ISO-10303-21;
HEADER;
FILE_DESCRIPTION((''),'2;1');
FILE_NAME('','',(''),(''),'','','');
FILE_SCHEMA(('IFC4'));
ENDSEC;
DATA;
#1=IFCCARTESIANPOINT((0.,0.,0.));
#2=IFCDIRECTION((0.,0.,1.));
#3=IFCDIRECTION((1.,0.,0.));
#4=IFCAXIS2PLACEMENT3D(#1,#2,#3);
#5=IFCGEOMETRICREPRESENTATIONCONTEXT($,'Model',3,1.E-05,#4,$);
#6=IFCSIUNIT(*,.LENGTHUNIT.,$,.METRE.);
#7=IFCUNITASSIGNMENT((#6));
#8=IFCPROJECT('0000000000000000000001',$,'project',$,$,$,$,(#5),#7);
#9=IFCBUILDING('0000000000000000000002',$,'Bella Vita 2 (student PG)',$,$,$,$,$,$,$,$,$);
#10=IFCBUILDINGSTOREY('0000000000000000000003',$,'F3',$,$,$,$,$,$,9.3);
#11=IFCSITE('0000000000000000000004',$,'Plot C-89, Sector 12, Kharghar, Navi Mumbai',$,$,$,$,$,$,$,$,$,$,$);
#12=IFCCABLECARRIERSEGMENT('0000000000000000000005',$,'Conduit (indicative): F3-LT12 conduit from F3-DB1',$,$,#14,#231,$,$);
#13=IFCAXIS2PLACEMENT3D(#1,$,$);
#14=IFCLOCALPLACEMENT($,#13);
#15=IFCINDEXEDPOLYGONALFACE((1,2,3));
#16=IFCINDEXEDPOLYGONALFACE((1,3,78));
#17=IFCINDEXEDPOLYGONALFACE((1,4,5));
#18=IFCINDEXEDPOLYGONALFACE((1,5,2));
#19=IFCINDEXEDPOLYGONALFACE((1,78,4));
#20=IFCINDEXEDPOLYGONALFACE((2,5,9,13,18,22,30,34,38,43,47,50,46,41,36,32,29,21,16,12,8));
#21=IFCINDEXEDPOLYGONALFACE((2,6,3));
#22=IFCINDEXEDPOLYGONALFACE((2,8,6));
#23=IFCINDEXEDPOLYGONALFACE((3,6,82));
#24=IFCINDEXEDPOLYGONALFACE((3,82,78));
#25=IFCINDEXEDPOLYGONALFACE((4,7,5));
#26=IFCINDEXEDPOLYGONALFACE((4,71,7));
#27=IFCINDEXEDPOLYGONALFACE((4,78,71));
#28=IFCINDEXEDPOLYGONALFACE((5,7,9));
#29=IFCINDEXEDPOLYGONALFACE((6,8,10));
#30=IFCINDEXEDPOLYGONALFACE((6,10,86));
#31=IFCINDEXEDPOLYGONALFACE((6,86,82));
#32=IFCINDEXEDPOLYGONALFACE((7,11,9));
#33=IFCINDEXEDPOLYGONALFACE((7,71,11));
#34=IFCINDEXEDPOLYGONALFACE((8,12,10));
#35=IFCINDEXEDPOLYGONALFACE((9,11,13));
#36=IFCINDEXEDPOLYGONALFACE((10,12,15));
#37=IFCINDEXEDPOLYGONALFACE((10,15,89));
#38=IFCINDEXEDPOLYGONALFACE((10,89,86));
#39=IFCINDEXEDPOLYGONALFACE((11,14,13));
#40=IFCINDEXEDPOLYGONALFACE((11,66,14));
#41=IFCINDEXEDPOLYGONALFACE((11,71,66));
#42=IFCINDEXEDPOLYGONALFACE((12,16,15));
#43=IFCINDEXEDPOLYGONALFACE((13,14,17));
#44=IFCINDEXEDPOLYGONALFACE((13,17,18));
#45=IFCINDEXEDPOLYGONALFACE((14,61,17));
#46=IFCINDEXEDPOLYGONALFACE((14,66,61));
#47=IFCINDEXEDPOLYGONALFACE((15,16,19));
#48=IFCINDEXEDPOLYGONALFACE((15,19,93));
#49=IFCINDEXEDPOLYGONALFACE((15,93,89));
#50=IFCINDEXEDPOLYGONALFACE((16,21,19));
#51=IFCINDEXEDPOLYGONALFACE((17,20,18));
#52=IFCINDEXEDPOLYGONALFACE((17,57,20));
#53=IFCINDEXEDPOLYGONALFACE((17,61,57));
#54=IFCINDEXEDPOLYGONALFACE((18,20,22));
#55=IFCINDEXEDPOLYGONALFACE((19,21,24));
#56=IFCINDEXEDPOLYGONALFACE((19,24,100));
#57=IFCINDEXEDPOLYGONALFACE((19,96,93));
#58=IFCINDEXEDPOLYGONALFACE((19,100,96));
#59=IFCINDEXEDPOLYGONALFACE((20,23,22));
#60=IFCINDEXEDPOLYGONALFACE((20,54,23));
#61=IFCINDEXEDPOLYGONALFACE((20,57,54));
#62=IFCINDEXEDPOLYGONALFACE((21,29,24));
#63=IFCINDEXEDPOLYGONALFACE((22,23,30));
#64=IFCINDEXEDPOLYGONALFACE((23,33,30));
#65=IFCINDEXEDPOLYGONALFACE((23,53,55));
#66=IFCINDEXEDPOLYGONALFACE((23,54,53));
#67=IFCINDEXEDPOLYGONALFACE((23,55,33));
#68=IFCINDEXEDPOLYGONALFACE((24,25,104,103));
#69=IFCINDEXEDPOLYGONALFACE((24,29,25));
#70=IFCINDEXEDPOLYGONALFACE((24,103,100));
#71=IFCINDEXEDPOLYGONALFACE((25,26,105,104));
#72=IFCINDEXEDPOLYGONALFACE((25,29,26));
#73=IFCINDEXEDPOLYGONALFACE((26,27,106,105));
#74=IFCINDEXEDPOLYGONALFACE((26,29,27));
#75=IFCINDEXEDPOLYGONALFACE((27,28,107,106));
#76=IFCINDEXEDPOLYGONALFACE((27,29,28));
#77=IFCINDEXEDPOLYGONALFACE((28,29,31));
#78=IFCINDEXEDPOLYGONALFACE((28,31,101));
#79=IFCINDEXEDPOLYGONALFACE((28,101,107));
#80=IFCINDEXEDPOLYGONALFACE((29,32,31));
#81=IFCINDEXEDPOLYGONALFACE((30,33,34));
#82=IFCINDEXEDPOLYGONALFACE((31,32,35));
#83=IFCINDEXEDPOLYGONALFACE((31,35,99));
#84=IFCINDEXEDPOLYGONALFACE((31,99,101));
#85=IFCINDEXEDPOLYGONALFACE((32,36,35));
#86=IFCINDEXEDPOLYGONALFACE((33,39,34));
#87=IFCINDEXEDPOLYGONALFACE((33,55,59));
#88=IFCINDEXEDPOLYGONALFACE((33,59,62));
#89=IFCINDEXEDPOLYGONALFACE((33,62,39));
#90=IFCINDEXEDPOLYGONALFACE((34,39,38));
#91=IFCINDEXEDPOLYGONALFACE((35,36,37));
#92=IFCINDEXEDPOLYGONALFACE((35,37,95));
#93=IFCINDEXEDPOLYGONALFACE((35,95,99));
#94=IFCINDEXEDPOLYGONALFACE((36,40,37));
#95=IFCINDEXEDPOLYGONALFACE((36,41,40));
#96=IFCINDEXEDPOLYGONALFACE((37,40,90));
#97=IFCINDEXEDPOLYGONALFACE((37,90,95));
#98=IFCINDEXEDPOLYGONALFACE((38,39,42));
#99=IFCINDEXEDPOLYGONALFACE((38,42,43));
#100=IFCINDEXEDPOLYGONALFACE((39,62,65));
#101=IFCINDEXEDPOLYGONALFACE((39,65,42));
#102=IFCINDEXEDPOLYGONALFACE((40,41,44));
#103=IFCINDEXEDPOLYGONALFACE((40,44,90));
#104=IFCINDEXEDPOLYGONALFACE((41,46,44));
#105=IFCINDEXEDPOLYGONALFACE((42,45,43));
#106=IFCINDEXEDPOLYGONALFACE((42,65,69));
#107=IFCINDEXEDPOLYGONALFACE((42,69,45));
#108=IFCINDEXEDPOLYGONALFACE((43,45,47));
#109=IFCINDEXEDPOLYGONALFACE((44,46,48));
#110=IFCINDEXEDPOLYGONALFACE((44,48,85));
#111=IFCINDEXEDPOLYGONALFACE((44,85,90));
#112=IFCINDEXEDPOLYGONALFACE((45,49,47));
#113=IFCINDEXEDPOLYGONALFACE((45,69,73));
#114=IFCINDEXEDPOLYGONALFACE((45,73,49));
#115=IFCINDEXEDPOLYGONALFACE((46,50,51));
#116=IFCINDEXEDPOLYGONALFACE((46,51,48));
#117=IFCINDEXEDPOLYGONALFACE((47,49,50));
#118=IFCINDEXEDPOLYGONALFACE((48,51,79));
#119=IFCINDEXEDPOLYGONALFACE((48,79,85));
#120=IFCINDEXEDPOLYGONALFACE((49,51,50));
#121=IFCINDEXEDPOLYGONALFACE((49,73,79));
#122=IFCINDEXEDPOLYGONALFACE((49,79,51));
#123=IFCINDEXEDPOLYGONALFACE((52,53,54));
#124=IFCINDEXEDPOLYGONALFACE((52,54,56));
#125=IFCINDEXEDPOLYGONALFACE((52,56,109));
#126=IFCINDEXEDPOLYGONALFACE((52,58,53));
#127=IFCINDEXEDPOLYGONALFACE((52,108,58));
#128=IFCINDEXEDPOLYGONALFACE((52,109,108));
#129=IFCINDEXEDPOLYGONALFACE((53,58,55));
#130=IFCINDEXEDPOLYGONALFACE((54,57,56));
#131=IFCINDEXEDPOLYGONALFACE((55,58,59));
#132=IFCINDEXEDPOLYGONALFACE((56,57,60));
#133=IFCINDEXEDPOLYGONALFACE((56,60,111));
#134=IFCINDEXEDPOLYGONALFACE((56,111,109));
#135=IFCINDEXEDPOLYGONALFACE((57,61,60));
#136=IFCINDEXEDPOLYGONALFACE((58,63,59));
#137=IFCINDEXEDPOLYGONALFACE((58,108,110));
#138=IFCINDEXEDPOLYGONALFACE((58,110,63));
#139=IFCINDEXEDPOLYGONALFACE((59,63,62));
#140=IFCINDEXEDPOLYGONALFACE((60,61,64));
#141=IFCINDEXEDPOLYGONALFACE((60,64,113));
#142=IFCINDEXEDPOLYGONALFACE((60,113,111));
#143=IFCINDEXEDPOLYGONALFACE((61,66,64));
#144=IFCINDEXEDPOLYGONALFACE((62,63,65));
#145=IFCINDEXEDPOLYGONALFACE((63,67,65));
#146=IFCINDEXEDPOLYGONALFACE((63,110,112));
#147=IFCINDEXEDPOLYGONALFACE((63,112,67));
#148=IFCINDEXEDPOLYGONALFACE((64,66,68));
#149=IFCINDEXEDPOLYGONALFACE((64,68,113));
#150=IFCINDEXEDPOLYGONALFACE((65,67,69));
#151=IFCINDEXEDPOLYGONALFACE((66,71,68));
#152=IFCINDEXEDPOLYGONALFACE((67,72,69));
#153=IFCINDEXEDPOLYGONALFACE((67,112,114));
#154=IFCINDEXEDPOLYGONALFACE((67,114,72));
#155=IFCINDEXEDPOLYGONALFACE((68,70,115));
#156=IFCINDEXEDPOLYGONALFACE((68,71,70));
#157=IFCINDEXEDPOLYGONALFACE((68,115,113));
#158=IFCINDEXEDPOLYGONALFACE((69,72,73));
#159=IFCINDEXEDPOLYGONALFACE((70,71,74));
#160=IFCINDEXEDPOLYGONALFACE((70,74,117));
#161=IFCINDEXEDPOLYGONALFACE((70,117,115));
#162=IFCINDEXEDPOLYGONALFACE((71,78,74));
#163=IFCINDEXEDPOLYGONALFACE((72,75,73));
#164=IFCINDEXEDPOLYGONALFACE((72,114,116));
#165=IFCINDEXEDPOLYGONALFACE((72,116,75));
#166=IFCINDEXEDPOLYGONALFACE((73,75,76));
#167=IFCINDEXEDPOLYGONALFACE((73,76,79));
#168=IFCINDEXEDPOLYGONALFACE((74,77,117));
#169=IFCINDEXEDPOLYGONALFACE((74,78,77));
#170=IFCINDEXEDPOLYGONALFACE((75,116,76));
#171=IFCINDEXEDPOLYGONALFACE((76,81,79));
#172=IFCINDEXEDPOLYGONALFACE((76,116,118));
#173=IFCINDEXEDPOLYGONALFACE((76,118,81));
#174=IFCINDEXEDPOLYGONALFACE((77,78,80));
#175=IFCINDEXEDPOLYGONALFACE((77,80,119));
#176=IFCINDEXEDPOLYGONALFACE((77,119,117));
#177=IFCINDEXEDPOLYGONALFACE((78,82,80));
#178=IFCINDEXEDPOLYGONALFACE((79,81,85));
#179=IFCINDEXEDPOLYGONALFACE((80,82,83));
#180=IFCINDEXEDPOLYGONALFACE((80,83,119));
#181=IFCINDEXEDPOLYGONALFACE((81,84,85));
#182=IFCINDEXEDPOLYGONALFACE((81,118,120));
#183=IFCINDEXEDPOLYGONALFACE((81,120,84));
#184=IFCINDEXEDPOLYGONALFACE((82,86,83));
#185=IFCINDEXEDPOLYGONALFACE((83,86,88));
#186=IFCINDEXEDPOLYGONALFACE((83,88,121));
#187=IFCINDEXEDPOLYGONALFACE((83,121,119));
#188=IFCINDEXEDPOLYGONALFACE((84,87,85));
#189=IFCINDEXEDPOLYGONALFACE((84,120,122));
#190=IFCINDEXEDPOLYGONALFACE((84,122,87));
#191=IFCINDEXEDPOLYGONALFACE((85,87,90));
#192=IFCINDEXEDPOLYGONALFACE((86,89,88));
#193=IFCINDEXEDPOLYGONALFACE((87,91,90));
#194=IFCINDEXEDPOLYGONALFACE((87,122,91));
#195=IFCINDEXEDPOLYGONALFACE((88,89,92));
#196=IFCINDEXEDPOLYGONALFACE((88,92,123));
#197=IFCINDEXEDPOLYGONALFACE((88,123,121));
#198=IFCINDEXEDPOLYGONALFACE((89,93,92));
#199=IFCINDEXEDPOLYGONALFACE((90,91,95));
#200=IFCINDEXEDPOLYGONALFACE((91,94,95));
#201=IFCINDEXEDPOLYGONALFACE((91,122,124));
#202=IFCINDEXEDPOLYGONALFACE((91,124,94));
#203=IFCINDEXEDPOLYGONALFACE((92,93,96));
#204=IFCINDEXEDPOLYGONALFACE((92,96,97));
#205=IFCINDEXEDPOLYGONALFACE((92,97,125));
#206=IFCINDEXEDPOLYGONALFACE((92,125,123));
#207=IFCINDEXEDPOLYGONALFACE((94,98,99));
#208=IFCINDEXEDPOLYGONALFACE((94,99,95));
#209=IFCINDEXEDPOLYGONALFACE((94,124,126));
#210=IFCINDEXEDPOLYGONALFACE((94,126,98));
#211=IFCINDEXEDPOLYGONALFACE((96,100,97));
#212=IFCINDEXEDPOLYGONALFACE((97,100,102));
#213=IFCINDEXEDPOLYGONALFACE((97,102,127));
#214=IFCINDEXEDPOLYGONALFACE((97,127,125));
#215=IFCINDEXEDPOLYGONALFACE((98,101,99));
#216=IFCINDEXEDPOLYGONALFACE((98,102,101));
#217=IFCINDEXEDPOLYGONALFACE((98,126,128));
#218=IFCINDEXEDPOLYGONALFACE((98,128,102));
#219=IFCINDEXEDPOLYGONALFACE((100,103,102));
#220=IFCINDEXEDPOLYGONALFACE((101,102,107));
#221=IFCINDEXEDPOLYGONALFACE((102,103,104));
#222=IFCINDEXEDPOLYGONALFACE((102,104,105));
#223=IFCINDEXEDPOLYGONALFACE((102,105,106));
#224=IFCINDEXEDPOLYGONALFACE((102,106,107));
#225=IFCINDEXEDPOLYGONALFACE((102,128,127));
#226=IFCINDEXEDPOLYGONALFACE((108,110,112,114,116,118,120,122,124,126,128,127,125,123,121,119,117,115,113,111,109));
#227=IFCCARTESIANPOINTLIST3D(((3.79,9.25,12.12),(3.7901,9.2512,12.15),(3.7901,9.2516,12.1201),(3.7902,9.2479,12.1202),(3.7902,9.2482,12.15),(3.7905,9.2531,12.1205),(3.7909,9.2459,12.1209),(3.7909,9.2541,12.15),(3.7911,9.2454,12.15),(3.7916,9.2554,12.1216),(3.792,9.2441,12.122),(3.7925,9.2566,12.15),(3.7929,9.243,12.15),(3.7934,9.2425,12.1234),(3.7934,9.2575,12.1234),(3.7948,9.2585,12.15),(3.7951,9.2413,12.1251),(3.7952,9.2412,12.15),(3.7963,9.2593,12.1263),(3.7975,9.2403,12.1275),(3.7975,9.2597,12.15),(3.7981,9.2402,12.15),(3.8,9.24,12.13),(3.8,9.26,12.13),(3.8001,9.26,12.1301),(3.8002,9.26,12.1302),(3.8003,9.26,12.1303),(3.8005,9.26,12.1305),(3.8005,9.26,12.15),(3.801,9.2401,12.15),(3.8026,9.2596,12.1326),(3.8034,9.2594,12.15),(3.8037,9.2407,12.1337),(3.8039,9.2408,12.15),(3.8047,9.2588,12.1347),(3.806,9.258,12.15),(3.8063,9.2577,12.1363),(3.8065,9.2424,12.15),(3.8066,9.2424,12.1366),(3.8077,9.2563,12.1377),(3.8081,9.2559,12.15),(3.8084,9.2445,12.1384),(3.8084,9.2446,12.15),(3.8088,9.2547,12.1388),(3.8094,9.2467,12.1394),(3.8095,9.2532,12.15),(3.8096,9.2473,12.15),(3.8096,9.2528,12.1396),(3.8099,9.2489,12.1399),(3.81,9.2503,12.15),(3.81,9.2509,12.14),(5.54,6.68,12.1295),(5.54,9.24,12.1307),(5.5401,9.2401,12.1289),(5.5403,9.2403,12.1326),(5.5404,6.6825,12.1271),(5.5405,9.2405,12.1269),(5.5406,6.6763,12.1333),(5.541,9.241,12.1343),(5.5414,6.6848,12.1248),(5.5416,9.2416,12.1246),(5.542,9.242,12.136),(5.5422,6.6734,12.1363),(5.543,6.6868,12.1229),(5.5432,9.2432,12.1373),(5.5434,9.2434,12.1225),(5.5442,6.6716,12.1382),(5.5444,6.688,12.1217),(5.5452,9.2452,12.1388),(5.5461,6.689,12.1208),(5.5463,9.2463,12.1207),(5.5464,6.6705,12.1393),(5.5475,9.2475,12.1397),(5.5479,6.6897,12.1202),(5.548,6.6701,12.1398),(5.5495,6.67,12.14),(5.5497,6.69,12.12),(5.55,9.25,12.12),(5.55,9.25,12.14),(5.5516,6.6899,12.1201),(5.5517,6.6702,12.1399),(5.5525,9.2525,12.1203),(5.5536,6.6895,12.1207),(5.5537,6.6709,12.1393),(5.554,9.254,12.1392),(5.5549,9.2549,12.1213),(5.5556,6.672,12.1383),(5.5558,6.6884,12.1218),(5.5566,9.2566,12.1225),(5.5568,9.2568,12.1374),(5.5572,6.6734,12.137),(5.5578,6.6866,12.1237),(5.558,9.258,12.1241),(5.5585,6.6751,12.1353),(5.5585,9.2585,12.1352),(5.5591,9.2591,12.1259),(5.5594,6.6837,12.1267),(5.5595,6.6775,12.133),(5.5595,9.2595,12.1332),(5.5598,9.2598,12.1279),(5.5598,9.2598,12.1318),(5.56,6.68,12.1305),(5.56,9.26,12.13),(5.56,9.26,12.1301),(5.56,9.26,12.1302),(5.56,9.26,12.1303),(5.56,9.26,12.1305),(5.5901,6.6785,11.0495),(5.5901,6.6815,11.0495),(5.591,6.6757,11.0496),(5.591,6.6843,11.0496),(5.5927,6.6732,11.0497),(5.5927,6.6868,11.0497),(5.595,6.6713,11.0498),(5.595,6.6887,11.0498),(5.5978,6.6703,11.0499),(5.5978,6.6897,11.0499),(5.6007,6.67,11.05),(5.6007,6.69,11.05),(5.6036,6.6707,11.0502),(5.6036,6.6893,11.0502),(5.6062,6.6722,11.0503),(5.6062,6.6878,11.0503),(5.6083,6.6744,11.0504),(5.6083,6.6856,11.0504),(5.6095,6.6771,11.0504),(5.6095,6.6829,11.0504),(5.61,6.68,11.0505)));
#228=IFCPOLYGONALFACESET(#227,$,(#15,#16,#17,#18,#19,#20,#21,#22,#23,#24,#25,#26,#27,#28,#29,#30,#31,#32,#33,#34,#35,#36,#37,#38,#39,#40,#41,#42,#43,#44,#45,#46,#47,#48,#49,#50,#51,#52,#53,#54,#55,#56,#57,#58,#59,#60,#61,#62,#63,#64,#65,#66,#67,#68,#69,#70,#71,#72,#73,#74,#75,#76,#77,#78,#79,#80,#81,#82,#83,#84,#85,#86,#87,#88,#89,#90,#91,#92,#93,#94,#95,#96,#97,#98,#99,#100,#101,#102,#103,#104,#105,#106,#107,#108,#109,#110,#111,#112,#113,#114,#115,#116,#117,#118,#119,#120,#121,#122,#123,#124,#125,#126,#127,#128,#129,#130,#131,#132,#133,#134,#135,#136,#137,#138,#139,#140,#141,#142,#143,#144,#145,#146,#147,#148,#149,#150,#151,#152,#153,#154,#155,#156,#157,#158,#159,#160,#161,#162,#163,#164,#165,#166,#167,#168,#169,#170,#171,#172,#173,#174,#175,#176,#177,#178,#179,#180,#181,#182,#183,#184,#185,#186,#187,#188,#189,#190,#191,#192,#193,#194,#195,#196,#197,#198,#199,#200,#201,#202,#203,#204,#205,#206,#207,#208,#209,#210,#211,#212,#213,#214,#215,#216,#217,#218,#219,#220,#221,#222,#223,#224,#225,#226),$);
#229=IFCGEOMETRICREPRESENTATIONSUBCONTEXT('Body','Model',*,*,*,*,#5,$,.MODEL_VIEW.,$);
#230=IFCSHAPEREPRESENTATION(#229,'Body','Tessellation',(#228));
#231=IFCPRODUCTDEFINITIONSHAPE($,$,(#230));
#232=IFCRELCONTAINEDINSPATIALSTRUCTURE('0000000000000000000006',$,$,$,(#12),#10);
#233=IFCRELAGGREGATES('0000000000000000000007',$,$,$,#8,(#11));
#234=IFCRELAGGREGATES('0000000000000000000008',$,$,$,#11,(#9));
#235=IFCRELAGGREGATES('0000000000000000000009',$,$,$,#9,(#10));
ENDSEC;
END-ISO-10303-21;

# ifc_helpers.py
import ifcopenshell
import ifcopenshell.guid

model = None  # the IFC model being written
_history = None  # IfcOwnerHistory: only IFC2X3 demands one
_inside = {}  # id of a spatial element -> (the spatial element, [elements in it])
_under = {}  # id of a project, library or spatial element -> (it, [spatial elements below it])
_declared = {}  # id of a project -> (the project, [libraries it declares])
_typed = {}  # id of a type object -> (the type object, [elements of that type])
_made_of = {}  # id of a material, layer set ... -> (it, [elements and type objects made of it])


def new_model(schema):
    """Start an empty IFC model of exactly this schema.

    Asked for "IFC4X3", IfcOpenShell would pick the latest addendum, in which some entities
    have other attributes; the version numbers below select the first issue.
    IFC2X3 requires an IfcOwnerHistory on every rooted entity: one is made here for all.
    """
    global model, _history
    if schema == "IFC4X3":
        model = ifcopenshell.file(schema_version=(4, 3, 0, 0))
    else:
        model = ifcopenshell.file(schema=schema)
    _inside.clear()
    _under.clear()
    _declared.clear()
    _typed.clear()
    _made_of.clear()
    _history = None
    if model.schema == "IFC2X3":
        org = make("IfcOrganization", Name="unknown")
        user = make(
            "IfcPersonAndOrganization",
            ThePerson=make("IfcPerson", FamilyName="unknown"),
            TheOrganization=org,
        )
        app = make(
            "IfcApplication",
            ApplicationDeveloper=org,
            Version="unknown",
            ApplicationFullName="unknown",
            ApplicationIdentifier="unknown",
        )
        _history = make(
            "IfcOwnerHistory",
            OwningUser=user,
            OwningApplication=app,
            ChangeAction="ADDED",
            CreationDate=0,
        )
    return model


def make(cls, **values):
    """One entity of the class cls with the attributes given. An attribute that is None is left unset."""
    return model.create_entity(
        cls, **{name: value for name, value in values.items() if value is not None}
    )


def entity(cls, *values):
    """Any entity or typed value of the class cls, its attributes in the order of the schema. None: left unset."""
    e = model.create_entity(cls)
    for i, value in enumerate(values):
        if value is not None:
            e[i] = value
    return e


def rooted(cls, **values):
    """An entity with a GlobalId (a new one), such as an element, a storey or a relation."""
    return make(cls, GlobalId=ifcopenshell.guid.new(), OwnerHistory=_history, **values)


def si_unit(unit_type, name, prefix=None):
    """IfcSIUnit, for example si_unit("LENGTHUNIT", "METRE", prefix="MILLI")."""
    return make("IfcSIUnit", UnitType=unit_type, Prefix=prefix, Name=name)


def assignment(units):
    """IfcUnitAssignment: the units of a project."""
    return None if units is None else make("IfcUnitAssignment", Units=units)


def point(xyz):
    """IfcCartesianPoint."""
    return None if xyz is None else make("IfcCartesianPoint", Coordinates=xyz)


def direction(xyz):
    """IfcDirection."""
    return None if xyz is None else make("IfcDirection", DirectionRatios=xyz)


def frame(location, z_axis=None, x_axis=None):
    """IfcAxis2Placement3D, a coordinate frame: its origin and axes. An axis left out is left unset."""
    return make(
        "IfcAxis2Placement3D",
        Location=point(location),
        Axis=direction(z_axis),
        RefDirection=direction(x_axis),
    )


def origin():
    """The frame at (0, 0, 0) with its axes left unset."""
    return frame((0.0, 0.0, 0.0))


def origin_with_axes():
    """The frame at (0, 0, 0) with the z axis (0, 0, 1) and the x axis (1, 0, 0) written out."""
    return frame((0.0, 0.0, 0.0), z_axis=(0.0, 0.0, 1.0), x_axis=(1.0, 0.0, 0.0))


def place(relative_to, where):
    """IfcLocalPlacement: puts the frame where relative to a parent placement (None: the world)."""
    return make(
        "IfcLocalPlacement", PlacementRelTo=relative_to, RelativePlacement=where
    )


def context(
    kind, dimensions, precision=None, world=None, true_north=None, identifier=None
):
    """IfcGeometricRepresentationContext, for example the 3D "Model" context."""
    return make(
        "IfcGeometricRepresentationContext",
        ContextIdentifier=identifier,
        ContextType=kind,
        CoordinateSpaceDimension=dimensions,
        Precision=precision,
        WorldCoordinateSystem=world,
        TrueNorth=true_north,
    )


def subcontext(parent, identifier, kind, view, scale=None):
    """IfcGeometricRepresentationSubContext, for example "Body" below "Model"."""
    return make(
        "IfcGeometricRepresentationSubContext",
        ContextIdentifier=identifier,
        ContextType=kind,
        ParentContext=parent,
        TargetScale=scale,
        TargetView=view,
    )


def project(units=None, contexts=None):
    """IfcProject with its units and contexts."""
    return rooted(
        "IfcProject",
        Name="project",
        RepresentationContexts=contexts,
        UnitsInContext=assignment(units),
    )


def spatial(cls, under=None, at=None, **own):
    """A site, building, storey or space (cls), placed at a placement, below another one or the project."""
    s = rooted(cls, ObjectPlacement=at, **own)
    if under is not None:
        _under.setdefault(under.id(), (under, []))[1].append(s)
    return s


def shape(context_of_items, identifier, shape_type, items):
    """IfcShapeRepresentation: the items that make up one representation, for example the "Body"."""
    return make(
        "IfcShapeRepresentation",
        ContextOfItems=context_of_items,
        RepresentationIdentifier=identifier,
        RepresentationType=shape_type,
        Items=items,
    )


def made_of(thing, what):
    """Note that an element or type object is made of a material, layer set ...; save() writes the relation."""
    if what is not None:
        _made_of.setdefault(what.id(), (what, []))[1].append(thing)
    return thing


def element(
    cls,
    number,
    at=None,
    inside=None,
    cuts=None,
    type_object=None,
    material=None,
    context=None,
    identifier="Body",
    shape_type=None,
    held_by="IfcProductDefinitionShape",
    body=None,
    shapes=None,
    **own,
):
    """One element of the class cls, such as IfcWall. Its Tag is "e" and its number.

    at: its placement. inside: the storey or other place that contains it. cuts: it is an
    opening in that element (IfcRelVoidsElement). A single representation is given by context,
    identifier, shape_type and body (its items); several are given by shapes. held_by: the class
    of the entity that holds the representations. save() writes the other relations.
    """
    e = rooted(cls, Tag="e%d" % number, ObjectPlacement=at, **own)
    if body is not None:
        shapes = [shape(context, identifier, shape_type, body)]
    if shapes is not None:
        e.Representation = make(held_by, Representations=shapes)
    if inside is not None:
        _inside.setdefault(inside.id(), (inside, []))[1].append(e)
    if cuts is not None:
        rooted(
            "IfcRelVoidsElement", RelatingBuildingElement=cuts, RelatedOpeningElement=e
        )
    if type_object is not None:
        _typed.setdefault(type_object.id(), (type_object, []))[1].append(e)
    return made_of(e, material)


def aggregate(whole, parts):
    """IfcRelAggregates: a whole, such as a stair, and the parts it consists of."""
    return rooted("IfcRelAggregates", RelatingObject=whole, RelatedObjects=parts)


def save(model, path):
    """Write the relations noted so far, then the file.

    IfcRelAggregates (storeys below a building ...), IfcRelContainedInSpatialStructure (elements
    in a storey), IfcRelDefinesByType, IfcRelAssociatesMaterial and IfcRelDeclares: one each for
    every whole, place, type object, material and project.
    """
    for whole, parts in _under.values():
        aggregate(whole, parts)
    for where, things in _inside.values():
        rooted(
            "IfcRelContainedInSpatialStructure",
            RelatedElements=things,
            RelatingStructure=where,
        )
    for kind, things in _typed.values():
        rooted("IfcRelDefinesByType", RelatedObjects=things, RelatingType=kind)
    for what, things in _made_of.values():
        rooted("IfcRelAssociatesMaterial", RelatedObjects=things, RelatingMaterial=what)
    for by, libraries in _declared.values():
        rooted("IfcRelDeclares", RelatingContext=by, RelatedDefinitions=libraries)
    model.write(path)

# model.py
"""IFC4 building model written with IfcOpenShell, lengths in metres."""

from ifc_helpers import new_model, entity, si_unit, origin, origin_with_axes, place, context, subcontext, project, spatial, element, save


model = new_model("IFC4")

# Units and contexts
model_context = context("Model", 3, precision=1e-05, world=origin_with_axes())
body_context = subcontext(model_context, "Body", "Model", "MODEL_VIEW")
ifc_project = project(units=[si_unit("LENGTHUNIT", "METRE")], contexts=[model_context])

# Site, building, storey
site = spatial("IfcSite", under=ifc_project, Name="Plot C-89, Sector 12, Kharghar, Navi Mumbai")
building = spatial("IfcBuilding", under=site, Name="Bella Vita 2 (student PG)")
storey = spatial("IfcBuildingStorey", under=building, Name="F3", Elevation=9.3)

# Cable carrier segment
cable_carrier_segment_1_placement = place(None, origin())
element("IfcCableCarrierSegment", 1, at=cable_carrier_segment_1_placement, inside=storey, Name="Conduit (indicative): F3-LT12 conduit from F3-DB1", context=body_context, shape_type="AdvancedSweptSolid", body=[
    entity("IfcSweptDiskSolid", entity("IfcPolyline", [entity("IfcCartesianPoint", [5.6, 6.68, 11.05]), entity("IfcCartesianPoint", [5.55, 6.68, 12.13]), entity("IfcCartesianPoint", [5.55, 9.25, 12.13]), entity("IfcCartesianPoint", [3.8, 9.25, 12.13]), entity("IfcCartesianPoint", [3.8, 9.25, 12.15])]), 0.01),
])

save(model, "model.ifc")
